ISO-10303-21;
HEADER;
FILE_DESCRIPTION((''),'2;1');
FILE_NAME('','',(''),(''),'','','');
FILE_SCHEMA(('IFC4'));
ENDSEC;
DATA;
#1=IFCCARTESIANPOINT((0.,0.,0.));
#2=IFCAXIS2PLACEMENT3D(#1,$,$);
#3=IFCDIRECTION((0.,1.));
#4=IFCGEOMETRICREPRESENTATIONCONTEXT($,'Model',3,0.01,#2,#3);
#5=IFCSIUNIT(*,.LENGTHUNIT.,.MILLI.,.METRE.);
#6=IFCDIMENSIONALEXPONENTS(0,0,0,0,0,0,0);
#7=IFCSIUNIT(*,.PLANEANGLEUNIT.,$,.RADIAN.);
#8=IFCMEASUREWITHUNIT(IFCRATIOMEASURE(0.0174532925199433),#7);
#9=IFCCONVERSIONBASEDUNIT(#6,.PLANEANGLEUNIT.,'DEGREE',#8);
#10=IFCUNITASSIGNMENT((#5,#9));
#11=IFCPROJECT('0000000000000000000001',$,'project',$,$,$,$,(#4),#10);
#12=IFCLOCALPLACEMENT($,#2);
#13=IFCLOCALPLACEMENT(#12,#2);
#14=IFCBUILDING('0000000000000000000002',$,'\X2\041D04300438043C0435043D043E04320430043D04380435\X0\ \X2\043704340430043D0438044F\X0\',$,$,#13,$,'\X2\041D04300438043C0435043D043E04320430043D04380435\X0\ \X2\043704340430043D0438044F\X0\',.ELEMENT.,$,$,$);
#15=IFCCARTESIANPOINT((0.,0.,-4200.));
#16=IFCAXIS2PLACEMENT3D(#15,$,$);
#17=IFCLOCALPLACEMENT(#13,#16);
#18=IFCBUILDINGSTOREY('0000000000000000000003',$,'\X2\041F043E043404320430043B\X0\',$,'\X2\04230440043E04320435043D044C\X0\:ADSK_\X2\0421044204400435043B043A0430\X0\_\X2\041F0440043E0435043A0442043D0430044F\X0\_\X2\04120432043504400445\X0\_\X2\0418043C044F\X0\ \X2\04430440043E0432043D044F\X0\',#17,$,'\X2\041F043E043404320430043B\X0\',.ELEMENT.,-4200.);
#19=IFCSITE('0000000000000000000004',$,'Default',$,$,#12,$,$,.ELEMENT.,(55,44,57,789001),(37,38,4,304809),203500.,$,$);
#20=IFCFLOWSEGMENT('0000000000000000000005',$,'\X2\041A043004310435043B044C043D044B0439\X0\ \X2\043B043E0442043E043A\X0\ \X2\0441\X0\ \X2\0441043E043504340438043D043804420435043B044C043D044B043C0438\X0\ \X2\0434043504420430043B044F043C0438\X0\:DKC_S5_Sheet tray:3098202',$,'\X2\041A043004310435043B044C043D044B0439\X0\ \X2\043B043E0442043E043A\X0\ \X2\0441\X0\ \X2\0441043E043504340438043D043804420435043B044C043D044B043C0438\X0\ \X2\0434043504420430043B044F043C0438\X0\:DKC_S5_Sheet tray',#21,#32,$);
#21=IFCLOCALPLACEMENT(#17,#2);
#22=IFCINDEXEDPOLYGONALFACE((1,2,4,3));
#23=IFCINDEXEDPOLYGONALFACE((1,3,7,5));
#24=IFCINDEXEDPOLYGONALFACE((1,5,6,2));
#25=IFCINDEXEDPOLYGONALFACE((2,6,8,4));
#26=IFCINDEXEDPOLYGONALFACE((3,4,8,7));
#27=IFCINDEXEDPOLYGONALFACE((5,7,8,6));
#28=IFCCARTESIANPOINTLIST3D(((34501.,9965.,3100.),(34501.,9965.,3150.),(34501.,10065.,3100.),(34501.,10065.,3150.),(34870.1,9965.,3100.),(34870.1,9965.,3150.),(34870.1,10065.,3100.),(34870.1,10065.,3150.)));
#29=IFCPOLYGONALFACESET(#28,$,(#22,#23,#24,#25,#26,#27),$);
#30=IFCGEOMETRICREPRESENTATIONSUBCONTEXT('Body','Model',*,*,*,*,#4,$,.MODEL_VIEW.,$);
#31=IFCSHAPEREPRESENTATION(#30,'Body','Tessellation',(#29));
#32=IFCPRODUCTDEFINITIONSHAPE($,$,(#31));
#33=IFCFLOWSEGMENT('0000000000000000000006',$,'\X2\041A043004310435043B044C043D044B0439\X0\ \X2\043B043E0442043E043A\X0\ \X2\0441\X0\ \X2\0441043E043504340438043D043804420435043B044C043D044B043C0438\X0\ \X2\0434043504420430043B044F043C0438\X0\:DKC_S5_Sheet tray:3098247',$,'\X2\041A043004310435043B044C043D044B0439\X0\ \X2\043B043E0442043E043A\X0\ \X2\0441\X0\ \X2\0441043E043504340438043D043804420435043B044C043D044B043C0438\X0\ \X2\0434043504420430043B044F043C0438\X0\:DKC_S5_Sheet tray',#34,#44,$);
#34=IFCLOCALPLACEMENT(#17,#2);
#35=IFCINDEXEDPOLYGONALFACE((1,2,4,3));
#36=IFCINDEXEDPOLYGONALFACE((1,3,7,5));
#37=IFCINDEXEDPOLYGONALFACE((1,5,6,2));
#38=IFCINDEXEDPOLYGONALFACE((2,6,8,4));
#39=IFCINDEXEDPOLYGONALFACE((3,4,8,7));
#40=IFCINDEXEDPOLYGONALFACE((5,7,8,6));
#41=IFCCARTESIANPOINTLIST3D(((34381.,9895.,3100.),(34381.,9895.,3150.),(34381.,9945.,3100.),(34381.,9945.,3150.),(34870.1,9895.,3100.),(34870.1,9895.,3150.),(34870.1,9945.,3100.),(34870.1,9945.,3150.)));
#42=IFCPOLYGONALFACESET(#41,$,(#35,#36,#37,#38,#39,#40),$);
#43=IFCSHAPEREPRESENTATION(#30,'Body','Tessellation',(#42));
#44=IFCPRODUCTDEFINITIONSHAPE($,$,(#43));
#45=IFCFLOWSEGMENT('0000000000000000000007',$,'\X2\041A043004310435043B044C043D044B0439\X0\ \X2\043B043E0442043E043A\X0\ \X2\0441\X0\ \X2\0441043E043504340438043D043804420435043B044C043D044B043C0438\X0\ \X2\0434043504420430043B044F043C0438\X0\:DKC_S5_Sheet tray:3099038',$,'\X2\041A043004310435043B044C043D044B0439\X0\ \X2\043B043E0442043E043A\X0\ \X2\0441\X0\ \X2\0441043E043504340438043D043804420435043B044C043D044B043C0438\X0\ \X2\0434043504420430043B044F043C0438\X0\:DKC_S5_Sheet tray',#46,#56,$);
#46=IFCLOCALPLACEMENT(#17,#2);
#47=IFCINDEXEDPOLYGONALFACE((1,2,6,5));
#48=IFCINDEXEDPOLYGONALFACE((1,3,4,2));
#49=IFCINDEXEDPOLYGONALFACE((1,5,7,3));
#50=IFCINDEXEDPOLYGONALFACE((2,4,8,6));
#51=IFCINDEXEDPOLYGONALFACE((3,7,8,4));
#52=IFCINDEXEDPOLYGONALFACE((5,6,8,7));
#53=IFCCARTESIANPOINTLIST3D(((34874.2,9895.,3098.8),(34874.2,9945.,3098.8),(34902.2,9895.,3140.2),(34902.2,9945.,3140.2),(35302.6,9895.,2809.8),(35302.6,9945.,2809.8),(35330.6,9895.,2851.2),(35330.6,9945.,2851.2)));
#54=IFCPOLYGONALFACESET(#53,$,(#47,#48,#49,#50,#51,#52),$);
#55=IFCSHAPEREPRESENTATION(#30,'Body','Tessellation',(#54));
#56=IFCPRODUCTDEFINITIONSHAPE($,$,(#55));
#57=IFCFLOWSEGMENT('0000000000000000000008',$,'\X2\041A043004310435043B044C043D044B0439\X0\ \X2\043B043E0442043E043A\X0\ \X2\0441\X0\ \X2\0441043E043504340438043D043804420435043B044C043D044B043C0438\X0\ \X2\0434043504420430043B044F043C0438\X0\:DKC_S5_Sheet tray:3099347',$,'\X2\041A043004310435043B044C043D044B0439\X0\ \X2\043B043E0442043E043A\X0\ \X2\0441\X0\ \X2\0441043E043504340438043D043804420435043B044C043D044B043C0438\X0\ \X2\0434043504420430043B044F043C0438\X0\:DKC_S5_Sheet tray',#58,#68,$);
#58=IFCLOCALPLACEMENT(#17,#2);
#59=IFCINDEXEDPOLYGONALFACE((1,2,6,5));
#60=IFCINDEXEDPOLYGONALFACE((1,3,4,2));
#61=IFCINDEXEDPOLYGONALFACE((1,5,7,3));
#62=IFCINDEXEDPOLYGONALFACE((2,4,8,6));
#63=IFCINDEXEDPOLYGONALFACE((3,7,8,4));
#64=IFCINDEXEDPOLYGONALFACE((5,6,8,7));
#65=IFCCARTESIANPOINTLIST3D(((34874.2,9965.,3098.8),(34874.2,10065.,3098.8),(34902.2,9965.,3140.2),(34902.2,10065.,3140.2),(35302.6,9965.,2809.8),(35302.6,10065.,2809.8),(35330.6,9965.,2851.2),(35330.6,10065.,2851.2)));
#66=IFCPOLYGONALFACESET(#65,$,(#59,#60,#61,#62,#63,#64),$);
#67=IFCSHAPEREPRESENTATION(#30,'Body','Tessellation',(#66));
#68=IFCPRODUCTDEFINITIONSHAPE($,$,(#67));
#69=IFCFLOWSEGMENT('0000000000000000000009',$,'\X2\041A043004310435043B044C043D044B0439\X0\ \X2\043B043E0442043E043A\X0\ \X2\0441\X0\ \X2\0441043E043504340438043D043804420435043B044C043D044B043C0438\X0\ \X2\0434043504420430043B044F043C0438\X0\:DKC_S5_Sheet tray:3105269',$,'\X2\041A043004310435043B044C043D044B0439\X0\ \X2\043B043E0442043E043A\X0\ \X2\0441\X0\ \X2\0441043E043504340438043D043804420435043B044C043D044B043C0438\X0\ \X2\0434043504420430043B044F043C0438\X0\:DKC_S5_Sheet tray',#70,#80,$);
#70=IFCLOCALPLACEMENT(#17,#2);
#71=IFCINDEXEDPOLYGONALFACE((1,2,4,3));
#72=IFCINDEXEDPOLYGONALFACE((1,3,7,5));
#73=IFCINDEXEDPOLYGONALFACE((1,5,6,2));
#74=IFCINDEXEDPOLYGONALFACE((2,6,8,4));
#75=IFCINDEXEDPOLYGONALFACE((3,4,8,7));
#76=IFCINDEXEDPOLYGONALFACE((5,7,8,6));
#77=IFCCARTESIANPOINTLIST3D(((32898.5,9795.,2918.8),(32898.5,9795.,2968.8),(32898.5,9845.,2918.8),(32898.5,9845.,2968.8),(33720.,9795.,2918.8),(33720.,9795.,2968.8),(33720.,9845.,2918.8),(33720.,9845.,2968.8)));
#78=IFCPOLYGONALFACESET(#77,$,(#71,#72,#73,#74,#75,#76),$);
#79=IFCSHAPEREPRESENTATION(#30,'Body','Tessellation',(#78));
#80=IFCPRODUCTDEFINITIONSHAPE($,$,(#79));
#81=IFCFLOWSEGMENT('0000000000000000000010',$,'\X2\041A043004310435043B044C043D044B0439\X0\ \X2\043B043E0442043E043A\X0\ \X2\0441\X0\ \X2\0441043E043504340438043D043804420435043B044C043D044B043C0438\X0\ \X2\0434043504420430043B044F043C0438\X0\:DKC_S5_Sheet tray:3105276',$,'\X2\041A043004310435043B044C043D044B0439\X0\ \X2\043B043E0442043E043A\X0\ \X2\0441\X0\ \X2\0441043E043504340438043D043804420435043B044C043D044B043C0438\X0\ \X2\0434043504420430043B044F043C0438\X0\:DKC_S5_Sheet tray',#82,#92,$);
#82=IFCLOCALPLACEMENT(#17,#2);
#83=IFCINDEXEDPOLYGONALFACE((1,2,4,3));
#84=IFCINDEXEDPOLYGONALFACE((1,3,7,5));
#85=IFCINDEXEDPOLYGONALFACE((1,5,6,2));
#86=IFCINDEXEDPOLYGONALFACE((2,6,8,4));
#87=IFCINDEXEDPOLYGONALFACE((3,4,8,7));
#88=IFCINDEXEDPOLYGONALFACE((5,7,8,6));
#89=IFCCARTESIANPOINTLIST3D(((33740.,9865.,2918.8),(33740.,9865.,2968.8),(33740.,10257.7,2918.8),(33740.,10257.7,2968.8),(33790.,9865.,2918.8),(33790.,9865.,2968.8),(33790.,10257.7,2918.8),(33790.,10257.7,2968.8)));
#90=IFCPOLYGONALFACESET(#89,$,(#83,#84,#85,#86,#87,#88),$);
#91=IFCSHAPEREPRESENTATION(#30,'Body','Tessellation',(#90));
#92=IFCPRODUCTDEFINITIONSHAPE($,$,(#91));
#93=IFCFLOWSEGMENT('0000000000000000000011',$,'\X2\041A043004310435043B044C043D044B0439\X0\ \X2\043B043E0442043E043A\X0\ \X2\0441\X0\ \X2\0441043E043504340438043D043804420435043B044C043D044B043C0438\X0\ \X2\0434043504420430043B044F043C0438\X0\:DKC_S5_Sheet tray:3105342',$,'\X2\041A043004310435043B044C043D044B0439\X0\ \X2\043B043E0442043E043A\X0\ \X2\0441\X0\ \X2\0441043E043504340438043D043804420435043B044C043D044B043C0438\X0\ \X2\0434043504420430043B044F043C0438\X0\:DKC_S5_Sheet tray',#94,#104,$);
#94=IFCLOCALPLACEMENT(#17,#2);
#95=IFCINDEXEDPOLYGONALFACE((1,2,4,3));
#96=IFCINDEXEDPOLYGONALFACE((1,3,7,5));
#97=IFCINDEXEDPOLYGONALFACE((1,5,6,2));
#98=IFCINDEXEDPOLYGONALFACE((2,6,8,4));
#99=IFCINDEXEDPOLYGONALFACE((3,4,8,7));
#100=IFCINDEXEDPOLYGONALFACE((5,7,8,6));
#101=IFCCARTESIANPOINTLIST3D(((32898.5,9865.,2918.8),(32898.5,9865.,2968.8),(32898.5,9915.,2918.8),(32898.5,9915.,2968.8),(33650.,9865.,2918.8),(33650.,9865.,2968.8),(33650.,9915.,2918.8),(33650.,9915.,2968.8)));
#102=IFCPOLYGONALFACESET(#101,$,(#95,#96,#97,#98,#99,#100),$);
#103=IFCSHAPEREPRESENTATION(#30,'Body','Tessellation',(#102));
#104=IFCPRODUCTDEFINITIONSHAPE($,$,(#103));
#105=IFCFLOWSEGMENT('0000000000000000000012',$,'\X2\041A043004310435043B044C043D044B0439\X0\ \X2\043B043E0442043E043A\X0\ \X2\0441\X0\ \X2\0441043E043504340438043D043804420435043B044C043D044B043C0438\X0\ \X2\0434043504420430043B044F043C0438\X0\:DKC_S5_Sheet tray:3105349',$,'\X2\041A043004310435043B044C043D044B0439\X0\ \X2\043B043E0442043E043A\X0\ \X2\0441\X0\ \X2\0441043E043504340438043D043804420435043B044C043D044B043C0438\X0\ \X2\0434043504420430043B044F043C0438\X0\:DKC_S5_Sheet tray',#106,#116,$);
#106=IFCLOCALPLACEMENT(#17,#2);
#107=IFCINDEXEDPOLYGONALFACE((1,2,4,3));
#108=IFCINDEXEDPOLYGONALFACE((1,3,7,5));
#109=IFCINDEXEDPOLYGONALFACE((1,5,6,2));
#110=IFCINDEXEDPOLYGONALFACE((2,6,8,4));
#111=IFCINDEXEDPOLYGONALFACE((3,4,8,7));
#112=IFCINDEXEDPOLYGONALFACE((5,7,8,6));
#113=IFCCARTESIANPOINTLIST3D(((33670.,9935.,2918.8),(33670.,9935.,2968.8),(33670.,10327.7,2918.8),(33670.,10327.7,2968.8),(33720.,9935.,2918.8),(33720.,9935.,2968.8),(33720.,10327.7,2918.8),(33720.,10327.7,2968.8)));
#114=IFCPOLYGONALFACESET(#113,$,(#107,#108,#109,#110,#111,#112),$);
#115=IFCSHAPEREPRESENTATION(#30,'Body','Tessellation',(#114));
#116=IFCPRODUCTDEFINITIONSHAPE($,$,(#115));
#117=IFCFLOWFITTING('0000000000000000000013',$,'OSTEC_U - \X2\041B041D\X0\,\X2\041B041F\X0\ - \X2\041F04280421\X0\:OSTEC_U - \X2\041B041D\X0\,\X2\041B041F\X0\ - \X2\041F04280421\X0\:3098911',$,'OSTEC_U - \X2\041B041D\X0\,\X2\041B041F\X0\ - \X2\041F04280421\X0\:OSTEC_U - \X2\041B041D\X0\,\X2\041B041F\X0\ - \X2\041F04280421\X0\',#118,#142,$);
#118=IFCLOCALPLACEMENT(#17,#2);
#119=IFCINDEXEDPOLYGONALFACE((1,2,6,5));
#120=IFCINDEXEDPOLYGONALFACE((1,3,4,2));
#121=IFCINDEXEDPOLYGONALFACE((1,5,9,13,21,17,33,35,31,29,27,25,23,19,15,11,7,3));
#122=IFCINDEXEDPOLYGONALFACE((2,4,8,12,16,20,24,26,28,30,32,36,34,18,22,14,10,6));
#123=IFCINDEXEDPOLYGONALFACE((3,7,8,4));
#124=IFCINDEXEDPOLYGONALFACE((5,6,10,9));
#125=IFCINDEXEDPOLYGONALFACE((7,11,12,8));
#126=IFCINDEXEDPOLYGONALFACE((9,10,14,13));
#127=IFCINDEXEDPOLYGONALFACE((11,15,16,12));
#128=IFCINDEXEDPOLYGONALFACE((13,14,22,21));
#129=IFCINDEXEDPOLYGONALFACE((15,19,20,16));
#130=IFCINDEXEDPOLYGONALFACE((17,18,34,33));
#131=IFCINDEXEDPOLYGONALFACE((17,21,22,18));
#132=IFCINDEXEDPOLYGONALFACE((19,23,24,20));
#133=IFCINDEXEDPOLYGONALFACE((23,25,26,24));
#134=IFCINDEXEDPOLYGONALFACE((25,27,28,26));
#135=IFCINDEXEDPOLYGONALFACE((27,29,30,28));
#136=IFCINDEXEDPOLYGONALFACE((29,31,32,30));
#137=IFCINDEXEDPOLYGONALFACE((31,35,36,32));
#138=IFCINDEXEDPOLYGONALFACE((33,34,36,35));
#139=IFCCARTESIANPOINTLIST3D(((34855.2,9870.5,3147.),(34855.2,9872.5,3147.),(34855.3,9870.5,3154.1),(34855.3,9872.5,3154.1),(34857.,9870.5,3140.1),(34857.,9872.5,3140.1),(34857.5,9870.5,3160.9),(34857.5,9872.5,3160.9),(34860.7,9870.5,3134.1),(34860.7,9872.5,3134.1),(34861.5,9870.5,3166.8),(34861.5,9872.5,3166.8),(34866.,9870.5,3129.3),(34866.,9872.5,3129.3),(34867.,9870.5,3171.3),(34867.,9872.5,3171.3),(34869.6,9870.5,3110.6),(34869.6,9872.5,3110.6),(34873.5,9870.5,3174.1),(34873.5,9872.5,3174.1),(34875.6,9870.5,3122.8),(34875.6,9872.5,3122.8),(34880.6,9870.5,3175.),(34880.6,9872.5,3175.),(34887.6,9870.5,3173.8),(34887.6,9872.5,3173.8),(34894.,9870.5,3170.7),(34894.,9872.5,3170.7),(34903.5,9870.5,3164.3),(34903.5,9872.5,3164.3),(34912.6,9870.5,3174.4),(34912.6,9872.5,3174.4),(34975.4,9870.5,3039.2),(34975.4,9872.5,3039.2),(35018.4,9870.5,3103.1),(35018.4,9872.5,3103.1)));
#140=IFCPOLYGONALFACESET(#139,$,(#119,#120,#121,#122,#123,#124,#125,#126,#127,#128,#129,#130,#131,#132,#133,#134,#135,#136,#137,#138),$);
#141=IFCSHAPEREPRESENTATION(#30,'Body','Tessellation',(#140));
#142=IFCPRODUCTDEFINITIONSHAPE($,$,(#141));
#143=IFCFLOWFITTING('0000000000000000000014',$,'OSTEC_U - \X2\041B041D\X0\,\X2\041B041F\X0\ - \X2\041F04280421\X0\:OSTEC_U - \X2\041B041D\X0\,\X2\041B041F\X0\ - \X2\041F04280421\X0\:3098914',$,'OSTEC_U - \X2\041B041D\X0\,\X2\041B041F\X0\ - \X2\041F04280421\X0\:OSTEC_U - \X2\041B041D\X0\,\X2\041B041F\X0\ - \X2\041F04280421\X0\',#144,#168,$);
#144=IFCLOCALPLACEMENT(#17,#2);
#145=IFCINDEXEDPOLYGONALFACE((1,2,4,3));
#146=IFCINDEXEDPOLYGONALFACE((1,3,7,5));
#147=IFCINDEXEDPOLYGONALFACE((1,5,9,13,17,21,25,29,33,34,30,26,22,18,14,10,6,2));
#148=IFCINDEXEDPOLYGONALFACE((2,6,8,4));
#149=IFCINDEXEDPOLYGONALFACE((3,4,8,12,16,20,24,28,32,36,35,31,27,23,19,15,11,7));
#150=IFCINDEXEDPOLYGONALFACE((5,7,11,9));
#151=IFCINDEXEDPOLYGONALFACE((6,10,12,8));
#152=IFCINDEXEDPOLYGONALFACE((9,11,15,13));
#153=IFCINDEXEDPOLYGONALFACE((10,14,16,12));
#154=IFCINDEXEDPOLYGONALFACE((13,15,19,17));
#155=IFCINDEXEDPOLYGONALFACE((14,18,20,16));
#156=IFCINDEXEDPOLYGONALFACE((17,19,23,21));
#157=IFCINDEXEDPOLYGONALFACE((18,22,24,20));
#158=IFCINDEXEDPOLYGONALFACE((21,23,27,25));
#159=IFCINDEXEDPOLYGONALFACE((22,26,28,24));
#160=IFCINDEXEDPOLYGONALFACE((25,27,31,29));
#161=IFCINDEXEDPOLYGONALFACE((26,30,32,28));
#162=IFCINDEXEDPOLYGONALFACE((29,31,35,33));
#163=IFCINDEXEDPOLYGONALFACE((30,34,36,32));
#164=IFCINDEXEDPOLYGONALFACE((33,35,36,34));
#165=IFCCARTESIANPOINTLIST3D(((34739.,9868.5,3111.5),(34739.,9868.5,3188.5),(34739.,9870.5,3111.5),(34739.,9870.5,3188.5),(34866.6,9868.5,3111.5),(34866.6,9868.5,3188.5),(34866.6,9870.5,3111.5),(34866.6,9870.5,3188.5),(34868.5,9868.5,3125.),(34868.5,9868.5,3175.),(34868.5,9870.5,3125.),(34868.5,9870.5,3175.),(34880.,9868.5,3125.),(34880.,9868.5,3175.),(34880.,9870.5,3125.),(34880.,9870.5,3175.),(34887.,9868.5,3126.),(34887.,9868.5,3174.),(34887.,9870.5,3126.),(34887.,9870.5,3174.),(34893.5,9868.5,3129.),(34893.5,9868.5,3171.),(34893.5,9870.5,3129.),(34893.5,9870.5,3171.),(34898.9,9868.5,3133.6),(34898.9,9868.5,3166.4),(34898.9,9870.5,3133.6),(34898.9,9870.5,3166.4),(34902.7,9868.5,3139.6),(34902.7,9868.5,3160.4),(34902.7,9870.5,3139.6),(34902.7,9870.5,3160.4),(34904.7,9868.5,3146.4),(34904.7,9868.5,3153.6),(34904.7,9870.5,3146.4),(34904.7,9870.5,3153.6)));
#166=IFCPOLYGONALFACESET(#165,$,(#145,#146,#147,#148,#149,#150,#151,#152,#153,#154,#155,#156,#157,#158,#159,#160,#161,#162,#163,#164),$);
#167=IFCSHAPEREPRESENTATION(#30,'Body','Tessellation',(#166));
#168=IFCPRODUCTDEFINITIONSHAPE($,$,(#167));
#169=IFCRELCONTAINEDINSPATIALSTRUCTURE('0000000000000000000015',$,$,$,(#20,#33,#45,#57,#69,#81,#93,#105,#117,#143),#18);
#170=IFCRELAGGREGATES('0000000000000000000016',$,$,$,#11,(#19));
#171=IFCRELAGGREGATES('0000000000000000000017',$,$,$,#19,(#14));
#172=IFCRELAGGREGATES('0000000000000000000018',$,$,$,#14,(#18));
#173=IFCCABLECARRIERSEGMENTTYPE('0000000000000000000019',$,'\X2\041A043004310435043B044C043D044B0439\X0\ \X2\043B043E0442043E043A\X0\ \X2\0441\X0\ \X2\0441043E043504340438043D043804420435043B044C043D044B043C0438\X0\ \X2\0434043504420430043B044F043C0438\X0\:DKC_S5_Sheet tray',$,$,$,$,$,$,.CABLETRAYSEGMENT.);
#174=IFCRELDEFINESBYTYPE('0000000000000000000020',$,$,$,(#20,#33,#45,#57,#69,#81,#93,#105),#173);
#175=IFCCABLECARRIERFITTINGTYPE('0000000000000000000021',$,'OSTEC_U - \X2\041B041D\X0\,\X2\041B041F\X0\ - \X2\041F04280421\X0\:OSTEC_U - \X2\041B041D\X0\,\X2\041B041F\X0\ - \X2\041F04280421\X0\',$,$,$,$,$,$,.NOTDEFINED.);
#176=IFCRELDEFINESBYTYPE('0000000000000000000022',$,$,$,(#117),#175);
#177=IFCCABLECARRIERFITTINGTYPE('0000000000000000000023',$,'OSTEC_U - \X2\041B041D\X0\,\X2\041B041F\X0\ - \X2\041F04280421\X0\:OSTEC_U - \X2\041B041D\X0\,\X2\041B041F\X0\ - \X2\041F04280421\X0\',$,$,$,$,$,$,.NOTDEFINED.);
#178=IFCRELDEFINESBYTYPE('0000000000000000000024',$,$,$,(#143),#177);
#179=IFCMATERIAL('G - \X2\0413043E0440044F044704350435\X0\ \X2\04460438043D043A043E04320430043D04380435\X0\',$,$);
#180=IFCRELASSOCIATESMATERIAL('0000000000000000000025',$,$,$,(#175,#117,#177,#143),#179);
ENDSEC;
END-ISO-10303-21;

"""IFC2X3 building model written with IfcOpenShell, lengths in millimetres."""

from ifc_helpers import new_model, entity, si_unit, converted_unit, direction, frame, frame_2d, origin, origin_2d_with_axis, place, context, subcontext, project, spatial, polyline, circle_curve, parameter, trimmed, segment, composite_curve, rectangle, outline, extrude, source, transform, mapped, material, type_object, type_shapes, element, save


model = new_model("IFC2X3")

# Units and contexts
model_context = context("Model", 3, precision=0.01, world=origin(), true_north=direction((0.0, 1.0)))
body_context = subcontext(model_context, "Body", "Model", "MODEL_VIEW")
ifc_project = project(units=[si_unit("LENGTHUNIT", "METRE", prefix="MILLI"), converted_unit("PLANEANGLEUNIT", "DEGREE", entity("IfcRatioMeasure", 0.0174532925199433), si_unit("PLANEANGLEUNIT", "RADIAN"), dimensions=[0, 0, 0, 0, 0, 0, 0])], contexts=[model_context])

# Site, building, storey
site_placement = place(None, origin())
site = spatial("IfcSite", under=ifc_project, at=site_placement, Name="Default", CompositionType="ELEMENT", RefLatitude=(55, 44, 57, 789001), RefLongitude=(37, 38, 4, 304809), RefElevation=203500.0)
building_placement = place(site_placement, origin())
building = spatial("IfcBuilding", under=site, at=building_placement, Name="Наименование здания", LongName="Наименование здания", CompositionType="ELEMENT")
storey_placement = place(building_placement, frame((0.0, 0.0, -4200.0)))
storey = spatial("IfcBuildingStorey", under=building, at=storey_placement, Name="Подвал", ObjectType="Уровень:ADSK_Стрелка_Проектная_Вверх_Имя уровня", LongName="Подвал", CompositionType="ELEMENT", Elevation=-4200.0)

# Flow segments
cable_carrier_segment_type = type_object("IfcCableCarrierSegmentType", Name="Кабельный лоток с соединительными деталями:DKC_S5_Sheet tray", PredefinedType="CABLETRAYSEGMENT")
flow_segment_1_placement = place(storey_placement, frame((34501.0, 9965.0, 3100.0)))
element("IfcFlowSegment", 1, at=flow_segment_1_placement, inside=storey, type_object=cable_carrier_segment_type, Name="Кабельный лоток с соединительными деталями:DKC_S5_Sheet tray:3098202", ObjectType="Кабельный лоток с соединительными деталями:DKC_S5_Sheet tray", context=body_context, shape_type="SweptSolid", body=[
    extrude(rectangle(XDim=369.1, YDim=100.0, at=origin_2d_with_axis()), frame((184.6, 50.0, 0.0)), (0.0, 0.0, 1.0), 50.0),
])
flow_segment_2_placement = place(storey_placement, frame((34381.0, 9895.0, 3100.0)))
element("IfcFlowSegment", 2, at=flow_segment_2_placement, inside=storey, type_object=cable_carrier_segment_type, Name="Кабельный лоток с соединительными деталями:DKC_S5_Sheet tray:3098247", ObjectType="Кабельный лоток с соединительными деталями:DKC_S5_Sheet tray", context=body_context, shape_type="SweptSolid", body=[
    extrude(rectangle(XDim=489.1, YDim=50.0, at=origin_2d_with_axis()), frame((244.6, 25.0, 0.0)), (0.0, 0.0, 1.0), 50.0),
])
flow_segment_3_placement = place(storey_placement, frame((34874.2, 9895.0, 2809.8)))
element("IfcFlowSegment", 3, at=flow_segment_3_placement, inside=storey, type_object=cable_carrier_segment_type, Name="Кабельный лоток с соединительными деталями:DKC_S5_Sheet tray:3099038", ObjectType="Кабельный лоток с соединительными деталями:DKC_S5_Sheet tray", context=body_context, shape_type="SweptSolid", body=[
    extrude(rectangle(XDim=50.0, YDim=50.0, at=frame_2d((0.0, 0.0), x_axis=(0.0, 1.0))), frame((14.0, 25.0, 309.7), z_axis=(0.829038, 0.0, -0.559193), x_axis=(0.0, 1.0, 0.0)), (0.0, 0.0, 1.0), 516.8),
])
flow_segment_4_placement = place(storey_placement, frame((34874.2, 9965.0, 2809.8)))
element("IfcFlowSegment", 4, at=flow_segment_4_placement, inside=storey, type_object=cable_carrier_segment_type, Name="Кабельный лоток с соединительными деталями:DKC_S5_Sheet tray:3099347", ObjectType="Кабельный лоток с соединительными деталями:DKC_S5_Sheet tray", context=body_context, shape_type="SweptSolid", body=[
    extrude(rectangle(XDim=50.0, YDim=100.0, at=frame_2d((0.0, 0.0), x_axis=(0.0, 1.0))), frame((14.0, 50.0, 309.7), z_axis=(0.829038, 0.0, -0.559193), x_axis=(0.0, 1.0, 0.0)), (0.0, 0.0, 1.0), 516.8),
])
flow_segment_5_placement = place(storey_placement, frame((32898.5, 9795.0, 2918.8)))
element("IfcFlowSegment", 5, at=flow_segment_5_placement, inside=storey, type_object=cable_carrier_segment_type, Name="Кабельный лоток с соединительными деталями:DKC_S5_Sheet tray:3105269", ObjectType="Кабельный лоток с соединительными деталями:DKC_S5_Sheet tray", context=body_context, shape_type="SweptSolid", body=[
    extrude(rectangle(XDim=821.5, YDim=50.0, at=origin_2d_with_axis()), frame((410.8, 25.0, 0.0)), (0.0, 0.0, 1.0), 50.0),
])
flow_segment_6_placement = place(storey_placement, frame((33740.0, 9865.0, 2918.8)))
element("IfcFlowSegment", 6, at=flow_segment_6_placement, inside=storey, type_object=cable_carrier_segment_type, Name="Кабельный лоток с соединительными деталями:DKC_S5_Sheet tray:3105276", ObjectType="Кабельный лоток с соединительными деталями:DKC_S5_Sheet tray", context=body_context, shape_type="SweptSolid", body=[
    extrude(rectangle(XDim=392.7, YDim=50.0, at=origin_2d_with_axis()), frame((25.0, 196.4, 0.0), z_axis=(0.0, 0.0, 1.0), x_axis=(0.0, 1.0, 0.0)), (0.0, 0.0, 1.0), 50.0),
])
flow_segment_7_placement = place(storey_placement, frame((32898.5, 9865.0, 2918.8)))
element("IfcFlowSegment", 7, at=flow_segment_7_placement, inside=storey, type_object=cable_carrier_segment_type, Name="Кабельный лоток с соединительными деталями:DKC_S5_Sheet tray:3105342", ObjectType="Кабельный лоток с соединительными деталями:DKC_S5_Sheet tray", context=body_context, shape_type="SweptSolid", body=[
    extrude(rectangle(XDim=751.5, YDim=50.0, at=origin_2d_with_axis()), frame((375.8, 25.0, 0.0)), (0.0, 0.0, 1.0), 50.0),
])
flow_segment_8_placement = place(storey_placement, frame((33670.0, 9935.0, 2918.8)))
element("IfcFlowSegment", 8, at=flow_segment_8_placement, inside=storey, type_object=cable_carrier_segment_type, Name="Кабельный лоток с соединительными деталями:DKC_S5_Sheet tray:3105349", ObjectType="Кабельный лоток с соединительными деталями:DKC_S5_Sheet tray", context=body_context, shape_type="SweptSolid", body=[
    extrude(rectangle(XDim=392.7, YDim=50.0, at=origin_2d_with_axis()), frame((25.0, 196.4, 0.0), z_axis=(0.0, 0.0, 1.0), x_axis=(0.0, 1.0, 0.0)), (0.0, 0.0, 1.0), 50.0),
])

# Flow fittings
ifc_material_1 = material(Name="G - Горячее цинкование")
cable_carrier_fitting_type_1 = type_object("IfcCableCarrierFittingType", Name="OSTEC_U - ЛН,ЛП - ПШС:OSTEC_U - ЛН,ЛП - ПШС", PredefinedType="NOTDEFINED", material=ifc_material_1)
shared_shape_1 = source(origin(), body_context, "Body", "SweptSolid", [
    extrude(outline(composite_curve([segment(trimmed(circle_curve(frame_2d((-41.5, 0.0), x_axis=(1.0, 0.0)), 25.0), [parameter(90.0)], [parameter(270.0)], True, "PARAMETER"), True, "CONTINUOUS"), segment(polyline([(-41.5, -25.0), (-30.0, -25.0)]), True, "CONTINUOUS"), segment(polyline([(-30.0, -25.0), (-28.1, -38.5)]), True, "CONTINUOUS"), segment(polyline([(-28.1, -38.5), (99.5, -38.5)]), True, "CONTINUOUS"), segment(polyline([(99.5, -38.5), (99.5, 38.5)]), True, "CONTINUOUS"), segment(polyline([(99.5, 38.5), (-28.1, 38.5)]), True, "CONTINUOUS"), segment(polyline([(-28.1, 38.5), (-30.0, 25.0)]), True, "CONTINUOUS"), segment(polyline([(-30.0, 25.0), (-41.5, 25.0)]), True, "CONTINUOUS")], self_intersect=False)), frame((41.5, 0.0, 0.0), z_axis=(0.0, 0.0, -1.0), x_axis=(1.0, 0.0, 0.0)), (0.0, 0.0, -1.0), 2.0),
])
type_shapes(cable_carrier_fitting_type_1, [shared_shape_1])
flow_fitting_1_placement = place(storey_placement, frame((34880.0, 9870.5, 3150.0), z_axis=(0.0, 1.0, 0.0), x_axis=(0.829038, 0.0, -0.559193)))
element("IfcFlowFitting", 9, at=flow_fitting_1_placement, inside=storey, type_object=cable_carrier_fitting_type_1, material=ifc_material_1, Name="OSTEC_U - ЛН,ЛП - ПШС:OSTEC_U - ЛН,ЛП - ПШС:3098911", ObjectType="OSTEC_U - ЛН,ЛП - ПШС:OSTEC_U - ЛН,ЛП - ПШС", context=body_context, shape_type="MappedRepresentation", body=[
    mapped(shared_shape_1, transform((0.0, 0.0, 0.0), scale=1.0)),
])
cable_carrier_fitting_type_2 = type_object("IfcCableCarrierFittingType", Name="OSTEC_U - ЛН,ЛП - ПШС:OSTEC_U - ЛН,ЛП - ПШС", PredefinedType="NOTDEFINED", material=ifc_material_1)
shared_shape_2 = source(origin(), body_context, "Body", "SweptSolid", [
    extrude(outline(composite_curve([segment(trimmed(circle_curve(frame_2d((-41.5, 0.0), x_axis=(1.0, 0.0)), 25.0), [parameter(90.0)], [parameter(270.0)], True, "PARAMETER"), True, "CONTINUOUS"), segment(polyline([(-41.5, -25.0), (-30.0, -25.0)]), True, "CONTINUOUS"), segment(polyline([(-30.0, -25.0), (-28.1, -38.5)]), True, "CONTINUOUS"), segment(polyline([(-28.1, -38.5), (99.5, -38.5)]), True, "CONTINUOUS"), segment(polyline([(99.5, -38.5), (99.5, 38.5)]), True, "CONTINUOUS"), segment(polyline([(99.5, 38.5), (-28.1, 38.5)]), True, "CONTINUOUS"), segment(polyline([(-28.1, 38.5), (-30.0, 25.0)]), True, "CONTINUOUS"), segment(polyline([(-30.0, 25.0), (-41.5, 25.0)]), True, "CONTINUOUS")], self_intersect=False)), frame((41.5, 0.0, 0.0)), (0.0, 0.0, 1.0), 2.0),
])
type_shapes(cable_carrier_fitting_type_2, [shared_shape_2])
flow_fitting_2_placement = place(storey_placement, frame((34880.0, 9868.5, 3150.0), z_axis=(0.0, 1.0, 0.0), x_axis=(-1.0, 0.0, 0.0)))
element("IfcFlowFitting", 10, at=flow_fitting_2_placement, inside=storey, type_object=cable_carrier_fitting_type_2, material=ifc_material_1, Name="OSTEC_U - ЛН,ЛП - ПШС:OSTEC_U - ЛН,ЛП - ПШС:3098914", ObjectType="OSTEC_U - ЛН,ЛП - ПШС:OSTEC_U - ЛН,ЛП - ПШС", context=body_context, shape_type="MappedRepresentation", body=[
    mapped(shared_shape_2, transform((0.0, 0.0, 0.0), scale=1.0)),
])

save(model, "model.ifc")
